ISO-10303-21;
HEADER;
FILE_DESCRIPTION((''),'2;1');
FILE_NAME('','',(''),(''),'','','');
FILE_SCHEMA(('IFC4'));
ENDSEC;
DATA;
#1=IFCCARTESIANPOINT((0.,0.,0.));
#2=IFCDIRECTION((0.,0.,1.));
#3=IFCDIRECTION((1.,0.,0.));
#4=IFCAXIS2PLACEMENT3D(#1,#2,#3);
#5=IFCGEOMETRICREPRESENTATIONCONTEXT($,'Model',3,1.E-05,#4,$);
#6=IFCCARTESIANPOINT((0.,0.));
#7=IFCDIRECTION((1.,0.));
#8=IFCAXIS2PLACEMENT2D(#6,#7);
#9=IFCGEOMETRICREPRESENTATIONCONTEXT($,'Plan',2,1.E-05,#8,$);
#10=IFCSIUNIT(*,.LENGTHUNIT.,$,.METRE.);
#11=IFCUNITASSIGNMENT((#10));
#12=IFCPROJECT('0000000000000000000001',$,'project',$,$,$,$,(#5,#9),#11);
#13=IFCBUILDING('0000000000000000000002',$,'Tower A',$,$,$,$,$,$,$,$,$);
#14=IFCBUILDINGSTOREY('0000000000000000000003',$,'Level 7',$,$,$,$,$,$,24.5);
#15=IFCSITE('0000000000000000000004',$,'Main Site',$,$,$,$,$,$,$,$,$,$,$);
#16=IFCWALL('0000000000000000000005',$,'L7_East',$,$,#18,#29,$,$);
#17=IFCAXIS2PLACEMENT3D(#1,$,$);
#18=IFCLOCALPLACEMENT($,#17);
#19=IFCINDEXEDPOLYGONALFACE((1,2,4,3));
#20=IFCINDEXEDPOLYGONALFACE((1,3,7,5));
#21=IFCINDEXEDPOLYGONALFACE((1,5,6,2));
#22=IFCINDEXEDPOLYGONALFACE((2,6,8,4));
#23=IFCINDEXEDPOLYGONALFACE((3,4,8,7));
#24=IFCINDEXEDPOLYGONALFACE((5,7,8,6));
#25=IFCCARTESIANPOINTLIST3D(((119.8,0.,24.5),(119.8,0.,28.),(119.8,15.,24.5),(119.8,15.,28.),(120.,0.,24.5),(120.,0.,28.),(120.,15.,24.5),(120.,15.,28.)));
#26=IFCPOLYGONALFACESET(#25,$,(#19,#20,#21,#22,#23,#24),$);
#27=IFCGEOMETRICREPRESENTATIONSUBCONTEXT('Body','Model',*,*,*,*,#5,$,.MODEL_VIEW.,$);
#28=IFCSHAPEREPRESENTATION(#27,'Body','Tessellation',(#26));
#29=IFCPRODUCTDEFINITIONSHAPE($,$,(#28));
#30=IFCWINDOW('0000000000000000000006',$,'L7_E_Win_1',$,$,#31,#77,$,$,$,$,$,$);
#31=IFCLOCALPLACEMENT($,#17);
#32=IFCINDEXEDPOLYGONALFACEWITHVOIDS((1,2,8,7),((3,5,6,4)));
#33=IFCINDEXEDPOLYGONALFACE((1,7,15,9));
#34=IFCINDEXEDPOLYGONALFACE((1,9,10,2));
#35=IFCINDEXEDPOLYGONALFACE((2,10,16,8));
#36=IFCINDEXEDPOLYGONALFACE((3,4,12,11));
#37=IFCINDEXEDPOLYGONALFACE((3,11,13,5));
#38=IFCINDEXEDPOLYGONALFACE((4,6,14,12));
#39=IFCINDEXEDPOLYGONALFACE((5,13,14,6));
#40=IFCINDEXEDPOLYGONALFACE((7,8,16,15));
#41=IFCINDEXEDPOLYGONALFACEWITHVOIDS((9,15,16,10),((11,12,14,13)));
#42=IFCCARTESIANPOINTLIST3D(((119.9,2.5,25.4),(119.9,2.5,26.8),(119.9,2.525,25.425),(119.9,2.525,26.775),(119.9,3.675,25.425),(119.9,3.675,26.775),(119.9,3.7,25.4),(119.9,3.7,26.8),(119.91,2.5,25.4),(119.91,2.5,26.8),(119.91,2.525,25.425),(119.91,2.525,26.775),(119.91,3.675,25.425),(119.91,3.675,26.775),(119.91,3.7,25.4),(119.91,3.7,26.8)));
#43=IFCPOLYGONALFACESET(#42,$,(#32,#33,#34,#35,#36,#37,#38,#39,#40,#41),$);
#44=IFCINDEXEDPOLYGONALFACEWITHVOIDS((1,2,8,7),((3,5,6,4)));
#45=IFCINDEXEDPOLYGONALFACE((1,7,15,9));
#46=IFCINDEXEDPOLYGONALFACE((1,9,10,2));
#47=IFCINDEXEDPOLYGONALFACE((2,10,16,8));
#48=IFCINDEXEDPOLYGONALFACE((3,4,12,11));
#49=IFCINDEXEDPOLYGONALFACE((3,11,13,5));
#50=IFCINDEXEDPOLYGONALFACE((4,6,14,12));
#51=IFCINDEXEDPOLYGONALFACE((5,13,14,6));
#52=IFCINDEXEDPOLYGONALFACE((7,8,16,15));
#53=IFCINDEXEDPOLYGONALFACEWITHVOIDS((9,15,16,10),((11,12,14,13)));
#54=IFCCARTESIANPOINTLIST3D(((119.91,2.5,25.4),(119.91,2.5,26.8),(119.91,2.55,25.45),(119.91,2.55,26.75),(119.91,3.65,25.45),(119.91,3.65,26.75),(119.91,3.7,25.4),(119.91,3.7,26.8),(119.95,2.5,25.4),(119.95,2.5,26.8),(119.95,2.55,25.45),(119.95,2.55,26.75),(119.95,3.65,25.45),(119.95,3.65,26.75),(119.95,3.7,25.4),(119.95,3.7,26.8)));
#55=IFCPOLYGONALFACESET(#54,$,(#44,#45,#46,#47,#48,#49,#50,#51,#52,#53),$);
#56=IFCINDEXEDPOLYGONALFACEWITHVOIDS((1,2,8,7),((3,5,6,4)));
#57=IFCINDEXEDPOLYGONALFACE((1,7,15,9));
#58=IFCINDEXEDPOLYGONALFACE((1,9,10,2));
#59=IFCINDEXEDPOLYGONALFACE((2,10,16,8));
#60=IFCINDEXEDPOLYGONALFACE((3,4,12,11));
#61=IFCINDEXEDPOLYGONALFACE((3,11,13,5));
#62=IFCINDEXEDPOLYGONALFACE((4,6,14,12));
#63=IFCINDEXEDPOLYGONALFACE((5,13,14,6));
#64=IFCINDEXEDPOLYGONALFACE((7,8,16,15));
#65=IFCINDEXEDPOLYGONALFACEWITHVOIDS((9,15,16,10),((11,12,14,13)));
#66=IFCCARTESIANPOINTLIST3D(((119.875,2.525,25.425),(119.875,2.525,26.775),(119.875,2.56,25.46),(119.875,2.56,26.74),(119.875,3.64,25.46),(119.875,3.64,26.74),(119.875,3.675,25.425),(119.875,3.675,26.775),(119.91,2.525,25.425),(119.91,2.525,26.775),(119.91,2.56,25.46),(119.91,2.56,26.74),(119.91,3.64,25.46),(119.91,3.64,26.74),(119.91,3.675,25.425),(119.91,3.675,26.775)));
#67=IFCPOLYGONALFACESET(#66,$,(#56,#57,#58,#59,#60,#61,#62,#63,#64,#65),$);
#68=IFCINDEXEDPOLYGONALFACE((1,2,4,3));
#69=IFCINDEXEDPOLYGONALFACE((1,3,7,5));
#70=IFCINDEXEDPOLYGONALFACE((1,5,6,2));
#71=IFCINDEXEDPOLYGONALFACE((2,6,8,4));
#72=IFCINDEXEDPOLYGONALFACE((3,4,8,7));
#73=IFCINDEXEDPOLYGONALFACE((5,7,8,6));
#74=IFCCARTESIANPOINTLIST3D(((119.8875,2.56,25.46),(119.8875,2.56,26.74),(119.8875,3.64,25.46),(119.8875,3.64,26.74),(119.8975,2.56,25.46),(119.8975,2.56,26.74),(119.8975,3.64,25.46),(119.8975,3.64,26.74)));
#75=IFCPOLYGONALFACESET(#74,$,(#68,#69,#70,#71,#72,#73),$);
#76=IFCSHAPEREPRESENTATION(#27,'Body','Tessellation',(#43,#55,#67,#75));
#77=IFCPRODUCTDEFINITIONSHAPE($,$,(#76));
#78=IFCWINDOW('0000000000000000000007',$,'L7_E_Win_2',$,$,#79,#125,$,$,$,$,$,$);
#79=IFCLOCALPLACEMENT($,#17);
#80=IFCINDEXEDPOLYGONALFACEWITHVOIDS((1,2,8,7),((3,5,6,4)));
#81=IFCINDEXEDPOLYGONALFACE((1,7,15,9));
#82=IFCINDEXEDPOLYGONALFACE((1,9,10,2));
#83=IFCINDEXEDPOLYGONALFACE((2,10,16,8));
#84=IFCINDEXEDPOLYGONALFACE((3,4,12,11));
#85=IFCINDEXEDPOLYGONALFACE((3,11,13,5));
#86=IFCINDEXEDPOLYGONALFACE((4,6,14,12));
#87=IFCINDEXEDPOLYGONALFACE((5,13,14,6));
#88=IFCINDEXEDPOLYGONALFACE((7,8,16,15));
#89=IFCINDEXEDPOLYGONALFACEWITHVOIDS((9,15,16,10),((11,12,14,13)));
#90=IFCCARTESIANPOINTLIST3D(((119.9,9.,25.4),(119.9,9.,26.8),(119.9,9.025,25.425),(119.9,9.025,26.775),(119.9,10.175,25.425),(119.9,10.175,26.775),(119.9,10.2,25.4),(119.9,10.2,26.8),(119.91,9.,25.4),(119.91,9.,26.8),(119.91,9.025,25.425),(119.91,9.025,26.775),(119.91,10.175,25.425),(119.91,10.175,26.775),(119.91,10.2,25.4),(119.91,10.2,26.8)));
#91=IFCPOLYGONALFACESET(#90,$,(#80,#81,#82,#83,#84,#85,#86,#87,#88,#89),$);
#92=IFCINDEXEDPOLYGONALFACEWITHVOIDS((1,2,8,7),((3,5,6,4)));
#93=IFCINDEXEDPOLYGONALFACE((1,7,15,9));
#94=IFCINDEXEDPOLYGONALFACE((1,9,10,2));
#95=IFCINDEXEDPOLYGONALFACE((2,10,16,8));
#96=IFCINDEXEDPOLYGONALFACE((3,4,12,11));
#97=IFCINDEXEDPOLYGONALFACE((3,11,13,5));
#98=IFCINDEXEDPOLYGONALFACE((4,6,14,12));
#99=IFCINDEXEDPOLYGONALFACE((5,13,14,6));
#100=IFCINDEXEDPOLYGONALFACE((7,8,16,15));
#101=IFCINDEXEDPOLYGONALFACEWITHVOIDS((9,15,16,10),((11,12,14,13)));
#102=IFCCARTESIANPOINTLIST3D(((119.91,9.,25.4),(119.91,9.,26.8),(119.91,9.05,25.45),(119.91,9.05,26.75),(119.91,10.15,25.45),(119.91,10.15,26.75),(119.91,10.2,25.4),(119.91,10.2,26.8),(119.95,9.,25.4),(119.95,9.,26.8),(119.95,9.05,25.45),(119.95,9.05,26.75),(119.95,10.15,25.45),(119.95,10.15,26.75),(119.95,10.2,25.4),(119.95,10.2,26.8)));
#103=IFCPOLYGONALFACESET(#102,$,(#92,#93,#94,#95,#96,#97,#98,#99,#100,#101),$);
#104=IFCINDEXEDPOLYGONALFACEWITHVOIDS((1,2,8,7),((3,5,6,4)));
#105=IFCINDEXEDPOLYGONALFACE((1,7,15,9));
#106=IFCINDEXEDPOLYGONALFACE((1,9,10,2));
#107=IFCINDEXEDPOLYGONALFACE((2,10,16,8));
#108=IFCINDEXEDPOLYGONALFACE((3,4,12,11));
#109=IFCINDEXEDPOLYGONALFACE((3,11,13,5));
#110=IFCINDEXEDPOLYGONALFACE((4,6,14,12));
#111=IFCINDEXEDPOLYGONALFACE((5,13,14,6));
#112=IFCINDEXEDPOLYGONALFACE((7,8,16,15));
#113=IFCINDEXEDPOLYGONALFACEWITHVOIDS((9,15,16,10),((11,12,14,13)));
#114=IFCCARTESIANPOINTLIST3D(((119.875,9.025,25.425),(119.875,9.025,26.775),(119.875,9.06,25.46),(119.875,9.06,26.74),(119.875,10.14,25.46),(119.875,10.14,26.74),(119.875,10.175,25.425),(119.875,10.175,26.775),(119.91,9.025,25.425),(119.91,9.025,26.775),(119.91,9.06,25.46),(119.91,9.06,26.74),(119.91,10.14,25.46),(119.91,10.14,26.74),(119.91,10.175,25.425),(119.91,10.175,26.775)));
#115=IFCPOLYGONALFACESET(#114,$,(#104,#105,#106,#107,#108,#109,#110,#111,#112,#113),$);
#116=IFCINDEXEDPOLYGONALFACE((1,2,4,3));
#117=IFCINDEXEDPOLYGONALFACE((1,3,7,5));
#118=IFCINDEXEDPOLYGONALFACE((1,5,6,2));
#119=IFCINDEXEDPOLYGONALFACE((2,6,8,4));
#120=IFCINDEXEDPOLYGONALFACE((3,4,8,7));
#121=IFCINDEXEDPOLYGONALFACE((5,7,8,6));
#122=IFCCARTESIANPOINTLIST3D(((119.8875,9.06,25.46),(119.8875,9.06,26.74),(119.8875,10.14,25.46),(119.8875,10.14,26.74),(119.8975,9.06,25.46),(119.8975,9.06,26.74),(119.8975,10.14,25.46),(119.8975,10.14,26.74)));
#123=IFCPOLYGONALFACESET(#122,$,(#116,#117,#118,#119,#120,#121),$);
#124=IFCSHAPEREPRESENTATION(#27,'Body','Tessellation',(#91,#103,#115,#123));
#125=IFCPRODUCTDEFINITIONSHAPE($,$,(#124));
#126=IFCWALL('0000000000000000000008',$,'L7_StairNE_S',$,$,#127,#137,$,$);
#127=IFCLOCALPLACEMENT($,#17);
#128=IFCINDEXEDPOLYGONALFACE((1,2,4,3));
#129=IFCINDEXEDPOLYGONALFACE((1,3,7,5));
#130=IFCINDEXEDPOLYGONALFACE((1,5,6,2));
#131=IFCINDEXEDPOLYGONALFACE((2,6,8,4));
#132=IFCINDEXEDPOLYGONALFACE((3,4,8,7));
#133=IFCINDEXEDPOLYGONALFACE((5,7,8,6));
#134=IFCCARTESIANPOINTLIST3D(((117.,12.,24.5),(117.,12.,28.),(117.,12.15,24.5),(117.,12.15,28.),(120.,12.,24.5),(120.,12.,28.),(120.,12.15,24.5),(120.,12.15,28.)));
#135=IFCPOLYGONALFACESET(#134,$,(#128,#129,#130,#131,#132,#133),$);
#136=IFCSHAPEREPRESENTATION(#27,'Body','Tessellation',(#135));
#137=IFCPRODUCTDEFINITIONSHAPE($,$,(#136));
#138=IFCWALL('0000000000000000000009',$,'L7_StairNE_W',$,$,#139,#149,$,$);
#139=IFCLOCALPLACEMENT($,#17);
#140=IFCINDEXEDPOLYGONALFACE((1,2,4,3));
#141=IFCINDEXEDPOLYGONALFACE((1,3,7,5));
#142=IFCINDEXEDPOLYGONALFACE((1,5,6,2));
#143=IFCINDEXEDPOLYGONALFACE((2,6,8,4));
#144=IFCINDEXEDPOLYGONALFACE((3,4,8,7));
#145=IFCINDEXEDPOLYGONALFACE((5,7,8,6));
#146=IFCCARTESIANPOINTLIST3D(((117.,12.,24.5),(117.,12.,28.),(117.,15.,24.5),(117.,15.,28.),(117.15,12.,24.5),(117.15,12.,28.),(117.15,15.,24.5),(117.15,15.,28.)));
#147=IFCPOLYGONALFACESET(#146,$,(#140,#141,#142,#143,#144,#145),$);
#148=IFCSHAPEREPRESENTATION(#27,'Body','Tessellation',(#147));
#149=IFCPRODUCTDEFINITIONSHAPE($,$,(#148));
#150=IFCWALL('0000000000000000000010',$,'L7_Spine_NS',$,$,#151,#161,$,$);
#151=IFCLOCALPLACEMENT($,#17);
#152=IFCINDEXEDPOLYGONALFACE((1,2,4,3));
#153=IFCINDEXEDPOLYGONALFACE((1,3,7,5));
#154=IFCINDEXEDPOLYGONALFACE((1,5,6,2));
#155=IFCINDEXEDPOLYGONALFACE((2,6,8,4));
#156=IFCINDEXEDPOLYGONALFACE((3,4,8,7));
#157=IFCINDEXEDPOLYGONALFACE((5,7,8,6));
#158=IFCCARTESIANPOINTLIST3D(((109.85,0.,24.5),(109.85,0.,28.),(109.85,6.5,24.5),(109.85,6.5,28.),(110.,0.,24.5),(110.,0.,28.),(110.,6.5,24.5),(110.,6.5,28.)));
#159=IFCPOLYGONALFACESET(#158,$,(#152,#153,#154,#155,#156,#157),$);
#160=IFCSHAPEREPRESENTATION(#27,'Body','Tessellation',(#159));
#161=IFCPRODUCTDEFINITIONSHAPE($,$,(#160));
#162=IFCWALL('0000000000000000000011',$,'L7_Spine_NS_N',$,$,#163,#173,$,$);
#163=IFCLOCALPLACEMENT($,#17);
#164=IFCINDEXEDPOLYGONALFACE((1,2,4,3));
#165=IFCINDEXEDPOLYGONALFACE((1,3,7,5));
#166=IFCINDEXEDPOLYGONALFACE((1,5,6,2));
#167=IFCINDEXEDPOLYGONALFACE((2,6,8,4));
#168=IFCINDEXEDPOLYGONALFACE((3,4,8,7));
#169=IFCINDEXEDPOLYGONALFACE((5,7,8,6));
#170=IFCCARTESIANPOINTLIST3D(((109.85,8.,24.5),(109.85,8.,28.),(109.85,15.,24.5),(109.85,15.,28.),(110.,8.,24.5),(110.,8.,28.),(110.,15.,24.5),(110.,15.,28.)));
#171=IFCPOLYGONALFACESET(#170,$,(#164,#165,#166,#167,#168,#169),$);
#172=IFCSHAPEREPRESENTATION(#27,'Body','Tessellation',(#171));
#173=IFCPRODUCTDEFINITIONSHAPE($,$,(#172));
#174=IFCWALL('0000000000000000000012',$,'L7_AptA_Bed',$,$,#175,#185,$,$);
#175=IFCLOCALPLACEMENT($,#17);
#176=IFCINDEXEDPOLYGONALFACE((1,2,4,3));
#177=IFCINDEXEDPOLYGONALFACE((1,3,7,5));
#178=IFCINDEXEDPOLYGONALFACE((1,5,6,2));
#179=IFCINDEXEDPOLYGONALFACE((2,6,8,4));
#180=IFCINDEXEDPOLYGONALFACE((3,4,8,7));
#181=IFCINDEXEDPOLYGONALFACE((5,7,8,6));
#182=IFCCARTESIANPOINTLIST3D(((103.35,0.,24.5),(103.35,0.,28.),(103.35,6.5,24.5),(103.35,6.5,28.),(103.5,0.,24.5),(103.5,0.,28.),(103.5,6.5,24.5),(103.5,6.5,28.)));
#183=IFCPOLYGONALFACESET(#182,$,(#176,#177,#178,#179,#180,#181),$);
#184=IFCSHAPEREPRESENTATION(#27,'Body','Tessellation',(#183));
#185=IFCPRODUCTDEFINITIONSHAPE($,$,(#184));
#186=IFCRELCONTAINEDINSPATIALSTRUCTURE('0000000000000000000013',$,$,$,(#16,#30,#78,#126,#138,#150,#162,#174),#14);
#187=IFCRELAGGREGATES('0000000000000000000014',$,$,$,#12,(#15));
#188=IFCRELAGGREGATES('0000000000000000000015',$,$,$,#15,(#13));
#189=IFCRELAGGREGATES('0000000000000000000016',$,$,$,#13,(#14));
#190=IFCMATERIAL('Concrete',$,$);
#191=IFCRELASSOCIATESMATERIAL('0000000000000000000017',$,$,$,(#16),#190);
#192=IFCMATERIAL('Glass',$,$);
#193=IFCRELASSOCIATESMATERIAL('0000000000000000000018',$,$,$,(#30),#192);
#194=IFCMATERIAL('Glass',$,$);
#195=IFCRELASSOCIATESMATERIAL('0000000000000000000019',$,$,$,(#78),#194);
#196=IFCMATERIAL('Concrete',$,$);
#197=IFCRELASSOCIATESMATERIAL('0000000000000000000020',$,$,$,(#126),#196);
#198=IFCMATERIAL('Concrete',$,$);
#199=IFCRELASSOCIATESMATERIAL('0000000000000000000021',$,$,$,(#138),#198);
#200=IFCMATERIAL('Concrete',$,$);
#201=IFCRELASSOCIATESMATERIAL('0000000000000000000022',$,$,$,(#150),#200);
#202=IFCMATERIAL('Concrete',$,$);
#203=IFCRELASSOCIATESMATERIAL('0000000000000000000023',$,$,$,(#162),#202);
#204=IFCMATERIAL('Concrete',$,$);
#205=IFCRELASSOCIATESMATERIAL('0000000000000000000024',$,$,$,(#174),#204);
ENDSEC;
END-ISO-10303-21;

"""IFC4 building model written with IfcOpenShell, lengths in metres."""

from ifc_helpers import new_model, si_unit, frame, origin_with_axes, origin_2d_with_axis, place, context, subcontext, project, spatial, line, indexed_curve, outline, extrude, material, element, fill, save


model = new_model("IFC4")

# Units and contexts
model_context = context("Model", 3, precision=1e-05, world=origin_with_axes())
plan_context = context("Plan", 2, precision=1e-05, world=origin_2d_with_axis())
body_context = subcontext(model_context, "Body", "Model", "MODEL_VIEW")
ifc_project = project(units=[si_unit("LENGTHUNIT", "METRE")], contexts=[model_context, plan_context])

# Site, building, storey
site = spatial("IfcSite", under=ifc_project, Name="Main Site")
building = spatial("IfcBuilding", under=site, Name="Tower A")
storey = spatial("IfcBuildingStorey", under=building, Name="Level 7", Elevation=24.5)

# Wall, openings, windows
ifc_material_1 = material(Name="Concrete")
wall_1_placement = place(None, frame((120.0, 0.0, 24.5), z_axis=(0.0, 0.0, 1.0), x_axis=(0.0, 1.0, 0.0)))
wall_1 = element("IfcWall", 1, at=wall_1_placement, inside=storey, material=ifc_material_1, Name="L7_East", context=body_context, shape_type="SweptSolid", body=[
    extrude(outline(indexed_curve([(0.0, 0.0), (0.0, 0.2), (15.0, 0.2), (15.0, 0.0), (0.0, 0.0)], self_intersect=False)), origin_with_axes(), (0.0, 0.0, 1.0), 3.5),
])
opening_1_placement = place(wall_1_placement, frame((2.5, 0.0, 0.9), z_axis=(0.0, 0.0, 1.0), x_axis=(0.0, -1.0, 0.0)))
opening_1 = element("IfcOpeningElement", 2, at=opening_1_placement, cuts=wall_1, context=body_context, shape_type="SweptSolid", body=[
    extrude(outline(indexed_curve([(0.0, 0.0), (0.0, 0.25), (1.2, 0.25), (1.2, 0.0), (0.0, 0.0)], self_intersect=False)), origin_with_axes(), (0.0, 0.0, 1.0), 1.4),
])
opening_2_placement = place(wall_1_placement, frame((9.0, 0.0, 0.9), z_axis=(0.0, 0.0, 1.0), x_axis=(0.0, -1.0, 0.0)))
opening_2 = element("IfcOpeningElement", 3, at=opening_2_placement, cuts=wall_1, context=body_context, shape_type="SweptSolid", body=[
    extrude(outline(indexed_curve([(0.0, 0.0), (0.0, 0.25), (1.2, 0.25), (1.2, 0.0), (0.0, 0.0)], self_intersect=False)), origin_with_axes(), (0.0, 0.0, 1.0), 1.4),
])
ifc_material_2 = material(Name="Glass")
window_1_placement = place(None, frame((120.0, 2.5, 25.4), z_axis=(0.0, 0.0, 1.0), x_axis=(0.0, 1.0, 0.0)))
window_1 = element("IfcWindow", 4, at=window_1_placement, inside=storey, material=ifc_material_2, Name="L7_E_Win_1", context=body_context, shape_type="SweptSolid", body=[
    extrude(outline(indexed_curve([(0.0, 0.0), (1.2, 0.0), (1.2, 1.4), (0.0, 1.4)], segments=[line(1, 2, 3, 4, 1)]), holes=[indexed_curve([(0.025, 0.025), (1.175, 0.025), (1.175, 1.375), (0.025, 1.375)], segments=[line(1, 2, 3, 4, 1)])]), frame((0.0, 0.09, 0.0), z_axis=(0.0, -1.0, 0.0), x_axis=(1.0, 0.0, 0.0)), (0.0, 0.0, -1.0), 0.01),
    extrude(outline(indexed_curve([(0.0, 0.0), (1.2, 0.0), (1.2, 1.4), (0.0, 1.4)], segments=[line(1, 2, 3, 4, 1)]), holes=[indexed_curve([(0.05, 0.05), (1.15, 0.05), (1.15, 1.35), (0.05, 1.35)], segments=[line(1, 2, 3, 4, 1)])]), frame((0.0, 0.05, 0.0), z_axis=(0.0, -1.0, 0.0), x_axis=(1.0, 0.0, 0.0)), (0.0, 0.0, -1.0), 0.04),
    extrude(outline(indexed_curve([(0.0, 0.0), (1.15, 0.0), (1.15, 1.35), (0.0, 1.35)], segments=[line(1, 2, 3, 4, 1)]), holes=[indexed_curve([(0.035, 0.035), (1.115, 0.035), (1.115, 1.315), (0.035, 1.315)], segments=[line(1, 2, 3, 4, 1)])]), frame((0.025, 0.09, 0.025), z_axis=(0.0, -1.0, 0.0), x_axis=(1.0, 0.0, 0.0)), (0.0, 0.0, -1.0), 0.035),
    extrude(outline(indexed_curve([(0.035, 0.035), (1.115, 0.035), (1.115, 1.315), (0.035, 1.315)], segments=[line(1, 2, 3, 4, 1)])), frame((0.025, 0.1025, 0.025), z_axis=(0.0, -1.0, 0.0), x_axis=(1.0, 0.0, 0.0)), (0.0, 0.0, -1.0), 0.01),
])
fill(opening_1, window_1)
ifc_material_3 = material(Name="Glass")
window_2_placement = place(None, frame((120.0, 9.0, 25.4), z_axis=(0.0, 0.0, 1.0), x_axis=(0.0, 1.0, 0.0)))
window_2 = element("IfcWindow", 5, at=window_2_placement, inside=storey, material=ifc_material_3, Name="L7_E_Win_2", context=body_context, shape_type="SweptSolid", body=[
    extrude(outline(indexed_curve([(0.0, 0.0), (1.2, 0.0), (1.2, 1.4), (0.0, 1.4)], segments=[line(1, 2, 3, 4, 1)]), holes=[indexed_curve([(0.025, 0.025), (1.175, 0.025), (1.175, 1.375), (0.025, 1.375)], segments=[line(1, 2, 3, 4, 1)])]), frame((0.0, 0.09, 0.0), z_axis=(0.0, -1.0, 0.0), x_axis=(1.0, 0.0, 0.0)), (0.0, 0.0, -1.0), 0.01),
    extrude(outline(indexed_curve([(0.0, 0.0), (1.2, 0.0), (1.2, 1.4), (0.0, 1.4)], segments=[line(1, 2, 3, 4, 1)]), holes=[indexed_curve([(0.05, 0.05), (1.15, 0.05), (1.15, 1.35), (0.05, 1.35)], segments=[line(1, 2, 3, 4, 1)])]), frame((0.0, 0.05, 0.0), z_axis=(0.0, -1.0, 0.0), x_axis=(1.0, 0.0, 0.0)), (0.0, 0.0, -1.0), 0.04),
    extrude(outline(indexed_curve([(0.0, 0.0), (1.15, 0.0), (1.15, 1.35), (0.0, 1.35)], segments=[line(1, 2, 3, 4, 1)]), holes=[indexed_curve([(0.035, 0.035), (1.115, 0.035), (1.115, 1.315), (0.035, 1.315)], segments=[line(1, 2, 3, 4, 1)])]), frame((0.025, 0.09, 0.025), z_axis=(0.0, -1.0, 0.0), x_axis=(1.0, 0.0, 0.0)), (0.0, 0.0, -1.0), 0.035),
    extrude(outline(indexed_curve([(0.035, 0.035), (1.115, 0.035), (1.115, 1.315), (0.035, 1.315)], segments=[line(1, 2, 3, 4, 1)])), frame((0.025, 0.1025, 0.025), z_axis=(0.0, -1.0, 0.0), x_axis=(1.0, 0.0, 0.0)), (0.0, 0.0, -1.0), 0.01),
])
fill(opening_2, window_2)

# Walls
ifc_material_4 = material(Name="Concrete")
wall_2_placement = place(None, frame((117.0, 12.0, 24.5), z_axis=(0.0, 0.0, 1.0), x_axis=(1.0, 0.0, 0.0)))
element("IfcWall", 6, at=wall_2_placement, inside=storey, material=ifc_material_4, Name="L7_StairNE_S", context=body_context, shape_type="SweptSolid", body=[
    extrude(outline(indexed_curve([(0.0, 0.0), (0.0, 0.15), (3.0, 0.15), (3.0, 0.0), (0.0, 0.0)], self_intersect=False)), origin_with_axes(), (0.0, 0.0, 1.0), 3.5),
])
ifc_material_5 = material(Name="Concrete")
wall_3_placement = place(None, frame((117.0, 15.0, 24.5), z_axis=(0.0, 0.0, 1.0), x_axis=(0.0, -1.0, 0.0)))
element("IfcWall", 7, at=wall_3_placement, inside=storey, material=ifc_material_5, Name="L7_StairNE_W", context=body_context, shape_type="SweptSolid", body=[
    extrude(outline(indexed_curve([(0.0, 0.0), (0.0, 0.15), (3.0, 0.15), (3.0, 0.0), (0.0, 0.0)], self_intersect=False)), origin_with_axes(), (0.0, 0.0, 1.0), 3.5),
])
ifc_material_6 = material(Name="Concrete")
wall_4_placement = place(None, frame((110.0, 0.0, 24.5), z_axis=(0.0, 0.0, 1.0), x_axis=(0.0, 1.0, 0.0)))
element("IfcWall", 8, at=wall_4_placement, inside=storey, material=ifc_material_6, Name="L7_Spine_NS", context=body_context, shape_type="SweptSolid", body=[
    extrude(outline(indexed_curve([(0.0, 0.0), (0.0, 0.15), (6.5, 0.15), (6.5, 0.0), (0.0, 0.0)], self_intersect=False)), origin_with_axes(), (0.0, 0.0, 1.0), 3.5),
])
ifc_material_7 = material(Name="Concrete")
wall_5_placement = place(None, frame((110.0, 8.0, 24.5), z_axis=(0.0, 0.0, 1.0), x_axis=(0.0, 1.0, 0.0)))
element("IfcWall", 9, at=wall_5_placement, inside=storey, material=ifc_material_7, Name="L7_Spine_NS_N", context=body_context, shape_type="SweptSolid", body=[
    extrude(outline(indexed_curve([(0.0, 0.0), (0.0, 0.15), (7.0, 0.15), (7.0, 0.0), (0.0, 0.0)], self_intersect=False)), origin_with_axes(), (0.0, 0.0, 1.0), 3.5),
])
ifc_material_8 = material(Name="Concrete")
wall_6_placement = place(None, frame((103.5, 0.0, 24.5), z_axis=(0.0, 0.0, 1.0), x_axis=(0.0, 1.0, 0.0)))
element("IfcWall", 10, at=wall_6_placement, inside=storey, material=ifc_material_8, Name="L7_AptA_Bed", context=body_context, shape_type="SweptSolid", body=[
    extrude(outline(indexed_curve([(0.0, 0.0), (0.0, 0.15), (6.5, 0.15), (6.5, 0.0), (0.0, 0.0)], self_intersect=False)), origin_with_axes(), (0.0, 0.0, 1.0), 3.5),
])

save(model, "model.ifc")
